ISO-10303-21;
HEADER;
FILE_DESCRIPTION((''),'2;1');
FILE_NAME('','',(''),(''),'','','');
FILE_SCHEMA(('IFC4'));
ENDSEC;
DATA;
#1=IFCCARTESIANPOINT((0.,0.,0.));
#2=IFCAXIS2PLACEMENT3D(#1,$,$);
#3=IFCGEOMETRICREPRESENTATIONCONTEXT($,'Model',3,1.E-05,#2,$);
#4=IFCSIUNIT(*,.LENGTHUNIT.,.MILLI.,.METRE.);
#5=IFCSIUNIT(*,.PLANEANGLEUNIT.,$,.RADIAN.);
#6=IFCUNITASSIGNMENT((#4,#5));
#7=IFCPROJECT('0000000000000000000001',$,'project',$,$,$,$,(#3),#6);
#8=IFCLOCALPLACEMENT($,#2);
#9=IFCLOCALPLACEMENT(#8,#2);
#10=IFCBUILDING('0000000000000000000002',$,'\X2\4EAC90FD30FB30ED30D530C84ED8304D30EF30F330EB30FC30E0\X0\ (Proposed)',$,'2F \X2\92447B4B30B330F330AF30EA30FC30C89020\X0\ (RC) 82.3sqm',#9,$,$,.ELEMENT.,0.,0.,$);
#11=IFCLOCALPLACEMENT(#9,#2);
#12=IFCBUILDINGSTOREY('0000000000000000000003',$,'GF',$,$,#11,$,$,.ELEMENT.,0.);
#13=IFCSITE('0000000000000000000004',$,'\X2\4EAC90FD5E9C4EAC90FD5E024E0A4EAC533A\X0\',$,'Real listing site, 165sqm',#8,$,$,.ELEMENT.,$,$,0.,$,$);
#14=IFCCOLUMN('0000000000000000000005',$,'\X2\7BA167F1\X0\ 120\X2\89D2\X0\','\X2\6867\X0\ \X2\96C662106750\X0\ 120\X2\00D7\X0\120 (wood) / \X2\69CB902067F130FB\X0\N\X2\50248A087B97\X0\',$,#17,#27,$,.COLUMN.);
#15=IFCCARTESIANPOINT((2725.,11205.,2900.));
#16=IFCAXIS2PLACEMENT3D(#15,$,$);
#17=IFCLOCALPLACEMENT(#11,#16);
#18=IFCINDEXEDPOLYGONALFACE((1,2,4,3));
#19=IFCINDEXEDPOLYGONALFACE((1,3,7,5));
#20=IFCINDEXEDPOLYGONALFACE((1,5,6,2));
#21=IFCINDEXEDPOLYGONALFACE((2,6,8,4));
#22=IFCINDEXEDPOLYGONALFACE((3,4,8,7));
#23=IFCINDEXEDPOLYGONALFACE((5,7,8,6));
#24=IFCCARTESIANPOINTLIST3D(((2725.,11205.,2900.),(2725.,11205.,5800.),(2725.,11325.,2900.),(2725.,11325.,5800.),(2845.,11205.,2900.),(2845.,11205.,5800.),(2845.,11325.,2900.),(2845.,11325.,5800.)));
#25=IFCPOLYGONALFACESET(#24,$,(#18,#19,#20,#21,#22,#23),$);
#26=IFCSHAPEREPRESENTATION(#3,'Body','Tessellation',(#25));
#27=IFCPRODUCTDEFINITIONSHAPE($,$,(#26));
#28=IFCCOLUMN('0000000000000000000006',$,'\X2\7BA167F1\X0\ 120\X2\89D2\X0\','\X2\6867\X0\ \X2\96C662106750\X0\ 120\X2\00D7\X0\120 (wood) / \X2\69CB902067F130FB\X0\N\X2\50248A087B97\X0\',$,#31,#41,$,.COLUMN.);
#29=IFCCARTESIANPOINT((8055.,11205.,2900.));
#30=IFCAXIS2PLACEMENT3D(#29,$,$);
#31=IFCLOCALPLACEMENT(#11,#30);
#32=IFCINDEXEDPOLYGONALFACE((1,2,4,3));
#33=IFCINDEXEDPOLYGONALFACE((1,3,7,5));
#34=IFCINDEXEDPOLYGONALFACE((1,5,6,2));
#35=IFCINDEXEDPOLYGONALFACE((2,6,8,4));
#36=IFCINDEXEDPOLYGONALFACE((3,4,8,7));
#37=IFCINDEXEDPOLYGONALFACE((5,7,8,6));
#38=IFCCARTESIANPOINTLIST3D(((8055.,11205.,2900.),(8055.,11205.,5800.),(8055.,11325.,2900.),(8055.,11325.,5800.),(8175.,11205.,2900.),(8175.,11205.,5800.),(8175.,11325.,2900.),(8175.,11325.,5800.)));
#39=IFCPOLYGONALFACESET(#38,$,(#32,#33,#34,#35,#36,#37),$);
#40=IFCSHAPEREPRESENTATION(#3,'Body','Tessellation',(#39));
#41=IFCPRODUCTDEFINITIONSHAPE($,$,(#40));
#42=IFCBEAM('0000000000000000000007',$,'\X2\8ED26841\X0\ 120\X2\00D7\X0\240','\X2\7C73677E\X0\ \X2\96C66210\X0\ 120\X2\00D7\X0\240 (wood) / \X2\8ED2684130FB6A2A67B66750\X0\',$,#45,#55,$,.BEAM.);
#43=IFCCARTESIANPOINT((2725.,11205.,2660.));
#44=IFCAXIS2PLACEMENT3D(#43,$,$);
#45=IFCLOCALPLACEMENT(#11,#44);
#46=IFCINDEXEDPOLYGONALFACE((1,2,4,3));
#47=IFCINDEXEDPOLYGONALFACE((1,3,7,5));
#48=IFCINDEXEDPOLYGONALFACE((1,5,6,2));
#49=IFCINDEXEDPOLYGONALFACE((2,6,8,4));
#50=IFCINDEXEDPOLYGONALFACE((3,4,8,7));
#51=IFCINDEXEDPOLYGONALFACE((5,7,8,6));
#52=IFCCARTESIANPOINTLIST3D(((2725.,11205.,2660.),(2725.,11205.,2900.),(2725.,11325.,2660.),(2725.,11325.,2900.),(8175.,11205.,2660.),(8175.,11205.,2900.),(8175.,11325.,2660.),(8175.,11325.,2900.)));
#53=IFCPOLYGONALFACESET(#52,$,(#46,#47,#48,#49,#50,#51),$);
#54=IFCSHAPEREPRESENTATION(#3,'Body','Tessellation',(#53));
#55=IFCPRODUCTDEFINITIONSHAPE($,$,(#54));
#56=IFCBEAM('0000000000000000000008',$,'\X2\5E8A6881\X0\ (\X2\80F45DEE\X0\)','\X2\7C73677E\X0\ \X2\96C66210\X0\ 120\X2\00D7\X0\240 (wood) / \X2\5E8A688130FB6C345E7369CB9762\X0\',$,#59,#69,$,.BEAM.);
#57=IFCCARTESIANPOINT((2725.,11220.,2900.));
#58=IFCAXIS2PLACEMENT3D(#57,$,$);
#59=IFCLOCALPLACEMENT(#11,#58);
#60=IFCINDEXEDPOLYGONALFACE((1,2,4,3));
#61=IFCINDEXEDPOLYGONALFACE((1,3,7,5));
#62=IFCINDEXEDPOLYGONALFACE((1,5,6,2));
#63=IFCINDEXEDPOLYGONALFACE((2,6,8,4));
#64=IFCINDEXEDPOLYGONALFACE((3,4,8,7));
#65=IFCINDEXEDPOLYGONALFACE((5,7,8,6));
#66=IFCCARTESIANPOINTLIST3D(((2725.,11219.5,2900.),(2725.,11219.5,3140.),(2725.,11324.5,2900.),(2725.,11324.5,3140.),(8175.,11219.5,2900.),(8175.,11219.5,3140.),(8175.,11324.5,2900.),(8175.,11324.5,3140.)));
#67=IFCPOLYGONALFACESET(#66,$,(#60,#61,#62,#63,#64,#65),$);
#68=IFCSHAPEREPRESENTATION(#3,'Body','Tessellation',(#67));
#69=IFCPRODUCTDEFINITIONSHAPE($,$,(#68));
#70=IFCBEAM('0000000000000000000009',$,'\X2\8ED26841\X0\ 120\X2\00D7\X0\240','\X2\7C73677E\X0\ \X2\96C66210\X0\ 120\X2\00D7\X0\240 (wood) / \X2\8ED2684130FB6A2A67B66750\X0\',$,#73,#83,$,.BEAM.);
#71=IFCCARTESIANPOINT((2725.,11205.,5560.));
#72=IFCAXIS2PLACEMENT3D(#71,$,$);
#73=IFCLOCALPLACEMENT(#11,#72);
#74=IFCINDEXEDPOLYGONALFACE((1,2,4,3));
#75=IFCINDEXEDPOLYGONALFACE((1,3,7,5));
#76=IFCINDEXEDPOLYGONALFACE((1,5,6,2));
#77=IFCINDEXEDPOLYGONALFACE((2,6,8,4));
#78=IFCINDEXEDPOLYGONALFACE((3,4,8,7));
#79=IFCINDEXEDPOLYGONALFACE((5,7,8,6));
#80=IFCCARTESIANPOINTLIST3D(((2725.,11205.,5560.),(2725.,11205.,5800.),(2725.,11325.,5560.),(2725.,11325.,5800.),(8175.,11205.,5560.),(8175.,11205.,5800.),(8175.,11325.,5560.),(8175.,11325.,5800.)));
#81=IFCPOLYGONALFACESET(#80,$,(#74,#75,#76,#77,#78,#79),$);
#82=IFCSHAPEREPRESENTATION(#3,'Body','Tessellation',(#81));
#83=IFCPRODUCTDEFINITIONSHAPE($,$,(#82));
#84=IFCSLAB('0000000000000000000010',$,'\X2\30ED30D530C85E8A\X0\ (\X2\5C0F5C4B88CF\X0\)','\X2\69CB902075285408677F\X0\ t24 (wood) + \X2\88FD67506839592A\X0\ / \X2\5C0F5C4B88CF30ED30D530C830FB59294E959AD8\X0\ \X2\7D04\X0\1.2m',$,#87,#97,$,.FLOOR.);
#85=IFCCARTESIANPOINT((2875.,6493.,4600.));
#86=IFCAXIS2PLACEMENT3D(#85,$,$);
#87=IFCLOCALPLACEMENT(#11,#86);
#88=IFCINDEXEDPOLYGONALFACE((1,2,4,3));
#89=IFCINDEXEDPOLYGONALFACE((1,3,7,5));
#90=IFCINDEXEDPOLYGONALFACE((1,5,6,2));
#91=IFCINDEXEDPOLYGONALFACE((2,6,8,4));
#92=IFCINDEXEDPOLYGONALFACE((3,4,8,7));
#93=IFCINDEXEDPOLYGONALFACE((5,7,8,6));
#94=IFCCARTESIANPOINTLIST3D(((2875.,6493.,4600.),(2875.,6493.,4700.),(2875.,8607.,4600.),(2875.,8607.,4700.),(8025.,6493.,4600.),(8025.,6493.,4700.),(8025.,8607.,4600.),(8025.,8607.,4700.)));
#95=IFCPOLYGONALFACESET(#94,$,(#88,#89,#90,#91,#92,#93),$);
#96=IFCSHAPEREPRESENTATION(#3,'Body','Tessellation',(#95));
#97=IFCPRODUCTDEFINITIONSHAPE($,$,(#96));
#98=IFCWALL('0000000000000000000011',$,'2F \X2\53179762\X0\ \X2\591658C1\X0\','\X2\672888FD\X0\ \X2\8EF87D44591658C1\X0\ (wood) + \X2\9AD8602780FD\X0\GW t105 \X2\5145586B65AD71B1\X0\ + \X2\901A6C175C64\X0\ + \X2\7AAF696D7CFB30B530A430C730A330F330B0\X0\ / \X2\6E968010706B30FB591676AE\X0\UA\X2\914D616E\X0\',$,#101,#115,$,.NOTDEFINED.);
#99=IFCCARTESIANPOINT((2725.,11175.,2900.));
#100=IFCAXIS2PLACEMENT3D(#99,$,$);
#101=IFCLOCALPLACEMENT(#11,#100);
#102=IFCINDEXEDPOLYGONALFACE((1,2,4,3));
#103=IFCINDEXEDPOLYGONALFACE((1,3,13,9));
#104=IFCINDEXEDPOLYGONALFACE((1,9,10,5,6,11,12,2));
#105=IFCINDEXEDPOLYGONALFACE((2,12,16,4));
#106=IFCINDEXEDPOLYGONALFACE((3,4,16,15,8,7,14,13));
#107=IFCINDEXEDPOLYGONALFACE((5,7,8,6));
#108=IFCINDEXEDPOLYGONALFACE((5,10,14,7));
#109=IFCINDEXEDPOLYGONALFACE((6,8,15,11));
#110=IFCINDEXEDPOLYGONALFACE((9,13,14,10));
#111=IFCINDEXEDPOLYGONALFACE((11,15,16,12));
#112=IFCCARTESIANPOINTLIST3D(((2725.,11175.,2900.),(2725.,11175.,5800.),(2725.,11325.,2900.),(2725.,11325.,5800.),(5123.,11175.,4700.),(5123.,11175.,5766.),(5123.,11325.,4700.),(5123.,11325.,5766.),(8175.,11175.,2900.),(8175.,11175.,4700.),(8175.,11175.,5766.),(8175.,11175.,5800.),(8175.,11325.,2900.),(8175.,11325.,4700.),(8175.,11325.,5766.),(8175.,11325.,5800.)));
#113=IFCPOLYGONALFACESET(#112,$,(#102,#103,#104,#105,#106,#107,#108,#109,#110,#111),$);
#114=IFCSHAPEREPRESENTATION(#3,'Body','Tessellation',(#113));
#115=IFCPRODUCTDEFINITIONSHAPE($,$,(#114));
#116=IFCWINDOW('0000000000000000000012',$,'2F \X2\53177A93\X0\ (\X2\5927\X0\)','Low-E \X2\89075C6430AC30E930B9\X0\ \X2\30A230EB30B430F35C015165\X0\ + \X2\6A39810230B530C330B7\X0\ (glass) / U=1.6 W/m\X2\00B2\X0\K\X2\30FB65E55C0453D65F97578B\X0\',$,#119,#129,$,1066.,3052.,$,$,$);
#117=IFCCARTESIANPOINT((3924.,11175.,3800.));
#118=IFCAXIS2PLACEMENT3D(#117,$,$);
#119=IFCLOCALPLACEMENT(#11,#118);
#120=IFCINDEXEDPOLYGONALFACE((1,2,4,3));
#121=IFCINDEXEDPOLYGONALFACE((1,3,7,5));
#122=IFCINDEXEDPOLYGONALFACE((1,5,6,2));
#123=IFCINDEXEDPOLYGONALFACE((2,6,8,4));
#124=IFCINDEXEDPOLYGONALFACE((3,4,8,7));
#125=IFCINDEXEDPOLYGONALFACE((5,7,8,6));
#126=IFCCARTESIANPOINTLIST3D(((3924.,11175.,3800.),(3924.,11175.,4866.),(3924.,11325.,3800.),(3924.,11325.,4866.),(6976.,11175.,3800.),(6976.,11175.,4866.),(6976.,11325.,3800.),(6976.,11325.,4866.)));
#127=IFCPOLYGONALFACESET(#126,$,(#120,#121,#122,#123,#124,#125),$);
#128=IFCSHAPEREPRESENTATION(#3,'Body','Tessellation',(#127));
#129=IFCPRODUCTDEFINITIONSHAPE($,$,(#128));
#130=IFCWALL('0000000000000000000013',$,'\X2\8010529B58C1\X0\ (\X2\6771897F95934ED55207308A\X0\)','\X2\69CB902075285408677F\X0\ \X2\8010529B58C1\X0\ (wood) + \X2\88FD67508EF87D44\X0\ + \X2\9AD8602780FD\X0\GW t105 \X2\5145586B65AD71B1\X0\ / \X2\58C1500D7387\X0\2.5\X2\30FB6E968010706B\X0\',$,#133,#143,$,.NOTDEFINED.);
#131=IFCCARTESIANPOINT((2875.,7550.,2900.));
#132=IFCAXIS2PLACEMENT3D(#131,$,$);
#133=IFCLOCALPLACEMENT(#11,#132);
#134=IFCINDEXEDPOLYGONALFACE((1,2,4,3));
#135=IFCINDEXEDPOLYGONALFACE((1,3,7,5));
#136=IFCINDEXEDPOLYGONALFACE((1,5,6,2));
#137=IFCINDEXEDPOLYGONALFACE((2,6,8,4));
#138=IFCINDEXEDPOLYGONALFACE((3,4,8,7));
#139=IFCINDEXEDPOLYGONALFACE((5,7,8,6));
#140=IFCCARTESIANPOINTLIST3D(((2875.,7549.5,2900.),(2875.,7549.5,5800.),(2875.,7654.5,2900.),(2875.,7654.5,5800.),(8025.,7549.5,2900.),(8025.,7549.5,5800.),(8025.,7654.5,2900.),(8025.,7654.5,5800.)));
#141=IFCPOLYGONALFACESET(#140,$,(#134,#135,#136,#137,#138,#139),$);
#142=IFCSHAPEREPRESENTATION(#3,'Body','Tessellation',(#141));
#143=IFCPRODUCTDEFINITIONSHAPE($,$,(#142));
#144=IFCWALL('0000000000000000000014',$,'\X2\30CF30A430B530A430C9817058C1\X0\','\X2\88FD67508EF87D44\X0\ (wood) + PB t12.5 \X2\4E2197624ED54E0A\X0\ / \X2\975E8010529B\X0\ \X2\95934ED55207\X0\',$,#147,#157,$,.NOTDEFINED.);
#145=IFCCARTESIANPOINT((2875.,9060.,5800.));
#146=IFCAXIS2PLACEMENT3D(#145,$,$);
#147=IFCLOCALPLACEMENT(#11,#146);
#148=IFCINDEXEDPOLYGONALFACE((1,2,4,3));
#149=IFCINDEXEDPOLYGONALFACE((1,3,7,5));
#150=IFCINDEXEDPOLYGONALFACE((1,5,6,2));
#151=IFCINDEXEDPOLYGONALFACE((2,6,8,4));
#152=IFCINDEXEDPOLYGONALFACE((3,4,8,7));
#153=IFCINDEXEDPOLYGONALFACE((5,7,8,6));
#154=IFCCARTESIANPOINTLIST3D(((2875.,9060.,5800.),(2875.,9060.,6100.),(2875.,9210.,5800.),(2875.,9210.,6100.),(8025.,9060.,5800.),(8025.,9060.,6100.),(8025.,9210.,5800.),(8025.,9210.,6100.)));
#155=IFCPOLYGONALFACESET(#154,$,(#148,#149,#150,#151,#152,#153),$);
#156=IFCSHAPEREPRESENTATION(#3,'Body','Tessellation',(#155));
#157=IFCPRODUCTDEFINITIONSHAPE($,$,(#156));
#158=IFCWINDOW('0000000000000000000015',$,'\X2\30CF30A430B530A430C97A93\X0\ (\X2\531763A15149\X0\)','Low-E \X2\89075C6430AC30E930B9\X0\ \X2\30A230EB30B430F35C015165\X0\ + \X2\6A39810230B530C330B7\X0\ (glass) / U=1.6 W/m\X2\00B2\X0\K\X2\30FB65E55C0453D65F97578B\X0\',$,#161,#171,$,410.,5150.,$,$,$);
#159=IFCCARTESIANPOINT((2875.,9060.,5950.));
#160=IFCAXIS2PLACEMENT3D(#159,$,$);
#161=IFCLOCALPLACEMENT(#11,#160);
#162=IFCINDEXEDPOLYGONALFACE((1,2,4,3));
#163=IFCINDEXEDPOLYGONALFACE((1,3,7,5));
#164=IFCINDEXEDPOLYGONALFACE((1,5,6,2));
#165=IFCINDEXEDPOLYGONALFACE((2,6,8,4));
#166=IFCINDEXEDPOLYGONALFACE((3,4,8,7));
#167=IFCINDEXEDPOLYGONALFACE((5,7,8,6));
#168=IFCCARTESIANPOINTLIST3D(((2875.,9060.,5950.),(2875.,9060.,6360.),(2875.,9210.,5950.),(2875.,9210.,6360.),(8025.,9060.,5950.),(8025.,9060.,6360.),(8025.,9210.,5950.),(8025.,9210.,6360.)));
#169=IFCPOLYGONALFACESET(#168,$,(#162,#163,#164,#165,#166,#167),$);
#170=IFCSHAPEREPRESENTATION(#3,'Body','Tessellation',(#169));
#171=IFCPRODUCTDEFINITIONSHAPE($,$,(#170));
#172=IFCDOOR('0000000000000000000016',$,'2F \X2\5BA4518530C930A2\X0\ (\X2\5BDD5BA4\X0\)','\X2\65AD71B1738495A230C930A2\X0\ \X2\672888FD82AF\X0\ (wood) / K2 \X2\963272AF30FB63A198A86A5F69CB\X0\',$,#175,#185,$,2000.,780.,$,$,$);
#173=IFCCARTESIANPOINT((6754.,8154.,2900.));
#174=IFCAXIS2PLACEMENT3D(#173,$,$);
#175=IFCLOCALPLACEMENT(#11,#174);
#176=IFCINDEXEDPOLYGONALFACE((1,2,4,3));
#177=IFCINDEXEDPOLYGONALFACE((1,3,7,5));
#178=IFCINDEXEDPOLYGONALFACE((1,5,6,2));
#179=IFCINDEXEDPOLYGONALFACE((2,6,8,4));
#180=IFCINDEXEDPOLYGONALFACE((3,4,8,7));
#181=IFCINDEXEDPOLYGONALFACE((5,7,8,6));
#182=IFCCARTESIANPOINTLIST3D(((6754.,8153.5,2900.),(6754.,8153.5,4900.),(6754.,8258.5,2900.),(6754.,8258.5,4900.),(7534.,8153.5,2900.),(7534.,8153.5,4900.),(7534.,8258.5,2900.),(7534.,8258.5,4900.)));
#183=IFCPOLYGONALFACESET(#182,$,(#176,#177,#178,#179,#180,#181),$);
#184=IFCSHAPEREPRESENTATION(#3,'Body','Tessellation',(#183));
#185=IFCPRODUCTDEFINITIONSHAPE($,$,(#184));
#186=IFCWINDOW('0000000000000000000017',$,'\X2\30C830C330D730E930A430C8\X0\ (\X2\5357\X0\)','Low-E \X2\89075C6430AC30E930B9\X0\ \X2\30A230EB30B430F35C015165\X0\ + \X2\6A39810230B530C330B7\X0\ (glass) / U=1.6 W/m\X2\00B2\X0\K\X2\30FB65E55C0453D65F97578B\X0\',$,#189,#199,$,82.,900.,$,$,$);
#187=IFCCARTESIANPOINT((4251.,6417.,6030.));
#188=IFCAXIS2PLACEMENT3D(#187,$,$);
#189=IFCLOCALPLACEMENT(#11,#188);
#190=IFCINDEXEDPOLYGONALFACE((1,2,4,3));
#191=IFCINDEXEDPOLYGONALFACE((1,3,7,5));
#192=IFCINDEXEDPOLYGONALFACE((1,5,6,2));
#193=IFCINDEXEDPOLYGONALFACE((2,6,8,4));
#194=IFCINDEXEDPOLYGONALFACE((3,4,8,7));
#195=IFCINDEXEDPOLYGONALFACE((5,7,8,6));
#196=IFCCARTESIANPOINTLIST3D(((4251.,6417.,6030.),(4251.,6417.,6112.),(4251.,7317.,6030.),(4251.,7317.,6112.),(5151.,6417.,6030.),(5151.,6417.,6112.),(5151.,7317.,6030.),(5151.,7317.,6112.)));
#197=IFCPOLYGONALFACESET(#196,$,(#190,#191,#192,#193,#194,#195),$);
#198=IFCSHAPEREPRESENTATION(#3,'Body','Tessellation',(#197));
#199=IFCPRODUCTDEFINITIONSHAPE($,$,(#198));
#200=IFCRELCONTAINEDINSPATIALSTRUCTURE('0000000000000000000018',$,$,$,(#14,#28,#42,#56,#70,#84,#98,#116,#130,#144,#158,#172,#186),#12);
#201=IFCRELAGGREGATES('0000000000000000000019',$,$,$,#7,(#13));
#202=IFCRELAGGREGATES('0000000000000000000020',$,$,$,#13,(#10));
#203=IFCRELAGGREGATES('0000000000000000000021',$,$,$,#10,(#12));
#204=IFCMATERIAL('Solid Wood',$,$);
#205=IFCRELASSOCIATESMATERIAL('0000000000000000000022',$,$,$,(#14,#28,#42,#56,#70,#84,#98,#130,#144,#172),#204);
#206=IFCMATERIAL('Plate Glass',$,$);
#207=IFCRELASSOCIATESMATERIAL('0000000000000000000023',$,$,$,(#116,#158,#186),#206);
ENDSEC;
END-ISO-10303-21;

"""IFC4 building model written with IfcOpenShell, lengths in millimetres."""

from ifc_helpers import new_model, si_unit, frame, frame_2d, origin, place, context, project, spatial, rectangle, extrude, material, element, fill, save


model = new_model("IFC4")

# Units and contexts
model_context = context("Model", 3, precision=1e-05, world=origin())
ifc_project = project(units=[si_unit("LENGTHUNIT", "METRE", prefix="MILLI"), si_unit("PLANEANGLEUNIT", "RADIAN")], contexts=[model_context])

# Site, building, storey
site_placement = place(None, origin())
site = spatial("IfcSite", under=ifc_project, at=site_placement, Name="京都府京都市上京区", ObjectType="Real listing site, 165sqm", CompositionType="ELEMENT", RefElevation=0.0)
building_placement = place(site_placement, origin())
building = spatial("IfcBuilding", under=site, at=building_placement, Name="京都・ロフト付きワンルーム (Proposed)", ObjectType="2F 鉄筋コンクリート造 (RC) 82.3sqm", CompositionType="ELEMENT", ElevationOfRefHeight=0.0, ElevationOfTerrain=0.0)
storey_placement = place(building_placement, origin())
storey = spatial("IfcBuildingStorey", under=building, at=storey_placement, Name="GF", CompositionType="ELEMENT", Elevation=0.0)

# Columns
ifc_material_1 = material(Name="Solid Wood")
column_1_placement = place(storey_placement, frame((2725.0, 11205.0, 2900.0)))
element("IfcColumn", 1, at=column_1_placement, inside=storey, material=ifc_material_1, Name="管柱 120角", Description="桧 集成材 120×120 (wood) / 構造柱・N値計算", PredefinedType="COLUMN", context=model_context, shape_type="SweptSolid", body=[
    extrude(rectangle(XDim=120.0, YDim=120.0, at=frame_2d((60.0, 60.0))), frame((2725.0, 11205.0, 2900.0)), (0.0, 0.0, 1.0), 2900.0),
])
column_2_placement = place(storey_placement, frame((8055.0, 11205.0, 2900.0)))
element("IfcColumn", 2, at=column_2_placement, inside=storey, material=ifc_material_1, Name="管柱 120角", Description="桧 集成材 120×120 (wood) / 構造柱・N値計算", PredefinedType="COLUMN", context=model_context, shape_type="SweptSolid", body=[
    extrude(rectangle(XDim=120.0, YDim=120.0, at=frame_2d((60.0, 60.0))), frame((8055.0, 11205.0, 2900.0)), (0.0, 0.0, 1.0), 2900.0),
])

# Beams
beam_1_placement = place(storey_placement, frame((2725.0, 11205.0, 2660.0)))
element("IfcBeam", 3, at=beam_1_placement, inside=storey, material=ifc_material_1, Name="軒桁 120×240", Description="米松 集成 120×240 (wood) / 軒桁・横架材", PredefinedType="BEAM", context=model_context, shape_type="SweptSolid", body=[
    extrude(rectangle(XDim=5450.0, YDim=120.0, at=frame_2d((2725.0, 60.0))), frame((2725.0, 11205.0, 2660.0)), (0.0, 0.0, 1.0), 240.0),
])
beam_2_placement = place(storey_placement, frame((2725.0, 11220.0, 2900.0)))
element("IfcBeam", 4, at=beam_2_placement, inside=storey, material=ifc_material_1, Name="床梁 (胴差)", Description="米松 集成 120×240 (wood) / 床梁・水平構面", PredefinedType="BEAM", context=model_context, shape_type="SweptSolid", body=[
    extrude(rectangle(XDim=5450.0, YDim=105.0, at=frame_2d((2725.0, 52.0))), frame((2725.0, 11220.0, 2900.0)), (0.0, 0.0, 1.0), 240.0),
])
beam_3_placement = place(storey_placement, frame((2725.0, 11205.0, 5560.0)))
element("IfcBeam", 5, at=beam_3_placement, inside=storey, material=ifc_material_1, Name="軒桁 120×240", Description="米松 集成 120×240 (wood) / 軒桁・横架材", PredefinedType="BEAM", context=model_context, shape_type="SweptSolid", body=[
    extrude(rectangle(XDim=5450.0, YDim=120.0, at=frame_2d((2725.0, 60.0))), frame((2725.0, 11205.0, 5560.0)), (0.0, 0.0, 1.0), 240.0),
])

# Slab
slab_placement = place(storey_placement, frame((2875.0, 6493.0, 4600.0)))
element("IfcSlab", 6, at=slab_placement, inside=storey, material=ifc_material_1, Name="ロフト床 (小屋裏)", Description="構造用合板 t24 (wood) + 製材根太 / 小屋裏ロフト・天井高 約1.2m", PredefinedType="FLOOR", context=model_context, shape_type="SweptSolid", body=[
    extrude(rectangle(XDim=5150.0, YDim=2114.0, at=frame_2d((2575.0, 1057.0))), frame((2875.0, 6493.0, 4600.0)), (0.0, 0.0, 1.0), 100.0),
])

# Wall, opening, window
wall_1_placement = place(storey_placement, frame((2725.0, 11175.0, 2900.0)))
wall_1 = element("IfcWall", 7, at=wall_1_placement, inside=storey, material=ifc_material_1, Name="2F 北面 外壁", Description="木製 軸組外壁 (wood) + 高性能GW t105 充填断熱 + 通気層 + 窯業系サイディング / 準耐火・外皮UA配慮", PredefinedType="NOTDEFINED", context=model_context, shape_type="SweptSolid", body=[
    extrude(rectangle(XDim=5450.0, YDim=150.0, at=frame_2d((2725.0, 75.0))), frame((2725.0, 11175.0, 2900.0)), (0.0, 0.0, 1.0), 2900.0),
])
opening_1_placement = place(storey_placement, frame((3924.0, 11175.0, 3800.0)))
opening_1 = element("IfcOpeningElement", 8, at=opening_1_placement, cuts=wall_1, PredefinedType="NOTDEFINED", context=model_context, shape_type="SweptSolid", body=[
    extrude(rectangle(XDim=3052.0, YDim=150.0, at=frame_2d((1526.0, 75.0))), frame((3924.0, 11175.0, 3800.0)), (0.0, 0.0, 1.0), 1066.0),
])
ifc_material_2 = material(Name="Plate Glass")
window_1_placement = place(storey_placement, frame((3924.0, 11175.0, 3800.0)))
window_1 = element("IfcWindow", 9, at=window_1_placement, inside=storey, material=ifc_material_2, Name="2F 北窓 (大)", Description="Low-E 複層ガラス アルゴン封入 + 樹脂サッシ (glass) / U=1.6 W/m²K・日射取得型", OverallHeight=1066.0, OverallWidth=3052.0, context=model_context, shape_type="SweptSolid", body=[
    extrude(rectangle(XDim=3052.0, YDim=150.0, at=frame_2d((1526.0, 75.0))), frame((3924.0, 11175.0, 3800.0)), (0.0, 0.0, 1.0), 1066.0),
])
fill(opening_1, window_1)

# Wall
wall_2_placement = place(storey_placement, frame((2875.0, 7550.0, 2900.0)))
element("IfcWall", 10, at=wall_2_placement, inside=storey, material=ifc_material_1, Name="耐力壁 (東西間仕切り)", Description="構造用合板 耐力壁 (wood) + 製材軸組 + 高性能GW t105 充填断熱 / 壁倍率2.5・準耐火", PredefinedType="NOTDEFINED", context=model_context, shape_type="SweptSolid", body=[
    extrude(rectangle(XDim=5150.0, YDim=105.0, at=frame_2d((2575.0, 52.0))), frame((2875.0, 7550.0, 2900.0)), (0.0, 0.0, 1.0), 2900.0),
])

# Wall, opening, window
wall_3_placement = place(storey_placement, frame((2875.0, 9060.0, 5800.0)))
wall_3 = element("IfcWall", 11, at=wall_3_placement, inside=storey, material=ifc_material_1, Name="ハイサイド腰壁", Description="製材軸組 (wood) + PB t12.5 両面仕上 / 非耐力 間仕切", PredefinedType="NOTDEFINED", context=model_context, shape_type="SweptSolid", body=[
    extrude(rectangle(XDim=5150.0, YDim=150.0, at=frame_2d((2575.0, 75.0))), frame((2875.0, 9060.0, 5800.0)), (0.0, 0.0, 1.0), 700.0),
])
opening_2_placement = place(storey_placement, frame((2875.0, 9060.0, 5950.0)))
opening_2 = element("IfcOpeningElement", 12, at=opening_2_placement, cuts=wall_3, PredefinedType="NOTDEFINED", context=model_context, shape_type="SweptSolid", body=[
    extrude(rectangle(XDim=5150.0, YDim=150.0, at=frame_2d((2575.0, 75.0))), frame((2875.0, 9060.0, 5950.0)), (0.0, 0.0, 1.0), 410.0),
])
window_2_placement = place(storey_placement, frame((2875.0, 9060.0, 5950.0)))
window_2 = element("IfcWindow", 13, at=window_2_placement, inside=storey, material=ifc_material_2, Name="ハイサイド窓 (北採光)", Description="Low-E 複層ガラス アルゴン封入 + 樹脂サッシ (glass) / U=1.6 W/m²K・日射取得型", OverallHeight=410.0, OverallWidth=5150.0, context=model_context, shape_type="SweptSolid", body=[
    extrude(rectangle(XDim=5150.0, YDim=150.0, at=frame_2d((2575.0, 75.0))), frame((2875.0, 9060.0, 5950.0)), (0.0, 0.0, 1.0), 410.0),
])
fill(opening_2, window_2)

# Door
door_placement = place(storey_placement, frame((6754.0, 8154.0, 2900.0)))
element("IfcDoor", 14, at=door_placement, inside=storey, material=ifc_material_1, Name="2F 室内ドア (寝室)", Description="断熱玄関ドア 木製芯 (wood) / K2 防犯・採風機構", OverallHeight=2000.0, OverallWidth=780.0, context=model_context, shape_type="SweptSolid", body=[
    extrude(rectangle(XDim=780.0, YDim=105.0, at=frame_2d((390.0, 52.0))), frame((6754.0, 8154.0, 2900.0)), (0.0, 0.0, 1.0), 2000.0),
])

# Window
window_3_placement = place(storey_placement, frame((4251.0, 6417.0, 6030.0)))
element("IfcWindow", 15, at=window_3_placement, inside=storey, material=ifc_material_2, Name="トップライト (南)", Description="Low-E 複層ガラス アルゴン封入 + 樹脂サッシ (glass) / U=1.6 W/m²K・日射取得型", OverallHeight=82.0, OverallWidth=900.0, context=model_context, shape_type="SweptSolid", body=[
    extrude(rectangle(XDim=900.0, YDim=900.0, at=frame_2d((450.0, 450.0))), frame((4251.0, 6417.0, 6030.0)), (0.0, 0.0, 1.0), 82.0),
])

save(model, "model.ifc")
